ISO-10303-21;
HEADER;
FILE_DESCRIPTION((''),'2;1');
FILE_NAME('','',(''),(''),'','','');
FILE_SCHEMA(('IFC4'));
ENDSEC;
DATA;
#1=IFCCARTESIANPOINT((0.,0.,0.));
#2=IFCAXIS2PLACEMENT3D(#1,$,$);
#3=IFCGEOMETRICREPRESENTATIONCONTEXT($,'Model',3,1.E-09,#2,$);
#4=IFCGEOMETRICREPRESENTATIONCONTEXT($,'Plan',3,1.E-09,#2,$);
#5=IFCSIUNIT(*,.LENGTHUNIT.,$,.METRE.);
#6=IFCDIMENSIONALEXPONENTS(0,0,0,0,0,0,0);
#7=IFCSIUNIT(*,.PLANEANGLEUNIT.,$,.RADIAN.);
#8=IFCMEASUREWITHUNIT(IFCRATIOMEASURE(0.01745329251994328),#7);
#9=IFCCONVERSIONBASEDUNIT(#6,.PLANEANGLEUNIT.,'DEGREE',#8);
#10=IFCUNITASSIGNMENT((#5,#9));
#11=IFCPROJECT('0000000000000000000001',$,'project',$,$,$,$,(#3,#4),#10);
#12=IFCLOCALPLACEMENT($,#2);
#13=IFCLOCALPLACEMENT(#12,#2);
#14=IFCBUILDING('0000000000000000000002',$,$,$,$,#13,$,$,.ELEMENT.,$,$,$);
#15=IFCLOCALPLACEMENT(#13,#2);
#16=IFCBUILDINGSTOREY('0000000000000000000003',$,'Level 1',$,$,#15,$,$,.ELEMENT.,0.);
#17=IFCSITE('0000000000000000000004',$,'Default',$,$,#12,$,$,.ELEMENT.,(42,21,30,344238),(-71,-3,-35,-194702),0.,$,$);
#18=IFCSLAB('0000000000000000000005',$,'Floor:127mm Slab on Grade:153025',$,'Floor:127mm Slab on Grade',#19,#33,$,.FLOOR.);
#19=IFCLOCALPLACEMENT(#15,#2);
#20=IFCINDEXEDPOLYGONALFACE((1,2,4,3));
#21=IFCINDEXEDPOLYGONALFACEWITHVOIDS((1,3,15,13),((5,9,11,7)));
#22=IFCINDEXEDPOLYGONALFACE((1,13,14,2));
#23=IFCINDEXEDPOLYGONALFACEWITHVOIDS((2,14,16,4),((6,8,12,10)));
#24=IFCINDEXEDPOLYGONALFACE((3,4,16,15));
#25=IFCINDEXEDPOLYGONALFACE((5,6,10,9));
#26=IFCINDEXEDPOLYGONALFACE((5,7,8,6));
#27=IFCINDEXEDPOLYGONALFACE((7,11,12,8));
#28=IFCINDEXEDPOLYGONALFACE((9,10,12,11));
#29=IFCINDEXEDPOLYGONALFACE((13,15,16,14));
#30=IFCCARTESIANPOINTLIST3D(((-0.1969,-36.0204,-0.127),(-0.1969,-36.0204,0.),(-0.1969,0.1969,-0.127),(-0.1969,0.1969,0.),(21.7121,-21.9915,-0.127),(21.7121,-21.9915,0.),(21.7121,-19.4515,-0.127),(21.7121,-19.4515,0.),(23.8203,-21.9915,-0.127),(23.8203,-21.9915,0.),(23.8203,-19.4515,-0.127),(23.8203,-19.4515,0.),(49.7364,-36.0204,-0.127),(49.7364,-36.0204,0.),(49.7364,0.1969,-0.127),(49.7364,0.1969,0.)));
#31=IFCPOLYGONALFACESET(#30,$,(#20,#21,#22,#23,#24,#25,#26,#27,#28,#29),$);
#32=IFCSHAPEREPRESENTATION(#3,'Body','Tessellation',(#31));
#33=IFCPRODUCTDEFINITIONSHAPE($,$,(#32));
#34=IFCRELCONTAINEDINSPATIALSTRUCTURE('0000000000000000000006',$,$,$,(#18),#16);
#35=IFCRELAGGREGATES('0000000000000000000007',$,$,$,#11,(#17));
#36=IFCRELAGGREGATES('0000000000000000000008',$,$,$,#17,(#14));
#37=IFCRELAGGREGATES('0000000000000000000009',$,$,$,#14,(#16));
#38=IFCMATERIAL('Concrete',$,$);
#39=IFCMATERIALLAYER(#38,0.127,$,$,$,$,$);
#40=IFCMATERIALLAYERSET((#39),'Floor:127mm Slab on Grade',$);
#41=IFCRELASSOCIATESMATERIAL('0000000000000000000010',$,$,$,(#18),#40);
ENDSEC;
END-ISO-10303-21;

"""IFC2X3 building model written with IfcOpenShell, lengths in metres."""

from ifc_helpers import new_model, entity, si_unit, converted_unit, frame, frame_2d, origin, origin_2d_with_axis, place, context, project, spatial, rectangle, extrude, material, layer, layer_set, layer_usage, element, save


model = new_model("IFC2X3")

# Units and contexts
model_context = context("Model", 3, precision=1e-09, world=origin())
plan_context = context("Plan", 3, precision=1e-09, world=origin())
ifc_project = project(units=[si_unit("LENGTHUNIT", "METRE"), converted_unit("PLANEANGLEUNIT", "DEGREE", entity("IfcRatioMeasure", 0.01745329251994328), si_unit("PLANEANGLEUNIT", "RADIAN"), dimensions=[0, 0, 0, 0, 0, 0, 0])], contexts=[model_context, plan_context])

# Site, building, storey
site_placement = place(None, origin())
site = spatial("IfcSite", under=ifc_project, at=site_placement, Name="Default", CompositionType="ELEMENT", RefLatitude=(42, 21, 30, 344238), RefLongitude=(-71, -3, -35, -194702), RefElevation=0.0)
building_placement = place(site_placement, origin())
building = spatial("IfcBuilding", under=site, at=building_placement, CompositionType="ELEMENT")
storey_placement = place(building_placement, origin())
storey = spatial("IfcBuildingStorey", under=building, at=storey_placement, Name="Level 1", CompositionType="ELEMENT", Elevation=0.0)

# Slab, opening
ifc_material_1 = material(Name="Concrete")
ifc_layer = layer(ifc_material_1, 0.127)
ifc_layer_set = layer_set([ifc_layer], Name="Floor:127mm Slab on Grade")
ifc_layer_usage = layer_usage(ifc_layer_set, "AXIS3", "POSITIVE", 0.0)
slab_placement = place(storey_placement, frame((-0.1969, -36.0204, -0.127)))
slab = element("IfcSlab", 1, at=slab_placement, inside=storey, material=ifc_layer_usage, Name="Floor:127mm Slab on Grade:153025", ObjectType="Floor:127mm Slab on Grade", PredefinedType="FLOOR", context=model_context, shape_type="SweptSolid", body=[
    extrude(rectangle(XDim=36.2173, YDim=49.9333, at=frame_2d((0.0, 0.0), x_axis=(0.0, -1.0))), frame((24.9667, 18.1087, 0.127), z_axis=(0.0, 0.0, -1.0), x_axis=(-1.0, 0.0, 0.0)), (0.0, 0.0, 1.0), 0.127),
])
opening_placement = place(slab_placement, frame((22.963, 15.299, 0.127)))
element("IfcOpeningElement", 2, at=opening_placement, cuts=slab, ObjectType="Opening", context=model_context, shape_type="SweptSolid", body=[
    extrude(rectangle(XDim=2.1082, YDim=2.54, at=origin_2d_with_axis()), frame((0.0, 0.0, 0.0), z_axis=(0.0, 0.0, -1.0), x_axis=(1.0, 0.0, 0.0)), (0.0, 0.0, 1.0), 0.127),
])

save(model, "model.ifc")
